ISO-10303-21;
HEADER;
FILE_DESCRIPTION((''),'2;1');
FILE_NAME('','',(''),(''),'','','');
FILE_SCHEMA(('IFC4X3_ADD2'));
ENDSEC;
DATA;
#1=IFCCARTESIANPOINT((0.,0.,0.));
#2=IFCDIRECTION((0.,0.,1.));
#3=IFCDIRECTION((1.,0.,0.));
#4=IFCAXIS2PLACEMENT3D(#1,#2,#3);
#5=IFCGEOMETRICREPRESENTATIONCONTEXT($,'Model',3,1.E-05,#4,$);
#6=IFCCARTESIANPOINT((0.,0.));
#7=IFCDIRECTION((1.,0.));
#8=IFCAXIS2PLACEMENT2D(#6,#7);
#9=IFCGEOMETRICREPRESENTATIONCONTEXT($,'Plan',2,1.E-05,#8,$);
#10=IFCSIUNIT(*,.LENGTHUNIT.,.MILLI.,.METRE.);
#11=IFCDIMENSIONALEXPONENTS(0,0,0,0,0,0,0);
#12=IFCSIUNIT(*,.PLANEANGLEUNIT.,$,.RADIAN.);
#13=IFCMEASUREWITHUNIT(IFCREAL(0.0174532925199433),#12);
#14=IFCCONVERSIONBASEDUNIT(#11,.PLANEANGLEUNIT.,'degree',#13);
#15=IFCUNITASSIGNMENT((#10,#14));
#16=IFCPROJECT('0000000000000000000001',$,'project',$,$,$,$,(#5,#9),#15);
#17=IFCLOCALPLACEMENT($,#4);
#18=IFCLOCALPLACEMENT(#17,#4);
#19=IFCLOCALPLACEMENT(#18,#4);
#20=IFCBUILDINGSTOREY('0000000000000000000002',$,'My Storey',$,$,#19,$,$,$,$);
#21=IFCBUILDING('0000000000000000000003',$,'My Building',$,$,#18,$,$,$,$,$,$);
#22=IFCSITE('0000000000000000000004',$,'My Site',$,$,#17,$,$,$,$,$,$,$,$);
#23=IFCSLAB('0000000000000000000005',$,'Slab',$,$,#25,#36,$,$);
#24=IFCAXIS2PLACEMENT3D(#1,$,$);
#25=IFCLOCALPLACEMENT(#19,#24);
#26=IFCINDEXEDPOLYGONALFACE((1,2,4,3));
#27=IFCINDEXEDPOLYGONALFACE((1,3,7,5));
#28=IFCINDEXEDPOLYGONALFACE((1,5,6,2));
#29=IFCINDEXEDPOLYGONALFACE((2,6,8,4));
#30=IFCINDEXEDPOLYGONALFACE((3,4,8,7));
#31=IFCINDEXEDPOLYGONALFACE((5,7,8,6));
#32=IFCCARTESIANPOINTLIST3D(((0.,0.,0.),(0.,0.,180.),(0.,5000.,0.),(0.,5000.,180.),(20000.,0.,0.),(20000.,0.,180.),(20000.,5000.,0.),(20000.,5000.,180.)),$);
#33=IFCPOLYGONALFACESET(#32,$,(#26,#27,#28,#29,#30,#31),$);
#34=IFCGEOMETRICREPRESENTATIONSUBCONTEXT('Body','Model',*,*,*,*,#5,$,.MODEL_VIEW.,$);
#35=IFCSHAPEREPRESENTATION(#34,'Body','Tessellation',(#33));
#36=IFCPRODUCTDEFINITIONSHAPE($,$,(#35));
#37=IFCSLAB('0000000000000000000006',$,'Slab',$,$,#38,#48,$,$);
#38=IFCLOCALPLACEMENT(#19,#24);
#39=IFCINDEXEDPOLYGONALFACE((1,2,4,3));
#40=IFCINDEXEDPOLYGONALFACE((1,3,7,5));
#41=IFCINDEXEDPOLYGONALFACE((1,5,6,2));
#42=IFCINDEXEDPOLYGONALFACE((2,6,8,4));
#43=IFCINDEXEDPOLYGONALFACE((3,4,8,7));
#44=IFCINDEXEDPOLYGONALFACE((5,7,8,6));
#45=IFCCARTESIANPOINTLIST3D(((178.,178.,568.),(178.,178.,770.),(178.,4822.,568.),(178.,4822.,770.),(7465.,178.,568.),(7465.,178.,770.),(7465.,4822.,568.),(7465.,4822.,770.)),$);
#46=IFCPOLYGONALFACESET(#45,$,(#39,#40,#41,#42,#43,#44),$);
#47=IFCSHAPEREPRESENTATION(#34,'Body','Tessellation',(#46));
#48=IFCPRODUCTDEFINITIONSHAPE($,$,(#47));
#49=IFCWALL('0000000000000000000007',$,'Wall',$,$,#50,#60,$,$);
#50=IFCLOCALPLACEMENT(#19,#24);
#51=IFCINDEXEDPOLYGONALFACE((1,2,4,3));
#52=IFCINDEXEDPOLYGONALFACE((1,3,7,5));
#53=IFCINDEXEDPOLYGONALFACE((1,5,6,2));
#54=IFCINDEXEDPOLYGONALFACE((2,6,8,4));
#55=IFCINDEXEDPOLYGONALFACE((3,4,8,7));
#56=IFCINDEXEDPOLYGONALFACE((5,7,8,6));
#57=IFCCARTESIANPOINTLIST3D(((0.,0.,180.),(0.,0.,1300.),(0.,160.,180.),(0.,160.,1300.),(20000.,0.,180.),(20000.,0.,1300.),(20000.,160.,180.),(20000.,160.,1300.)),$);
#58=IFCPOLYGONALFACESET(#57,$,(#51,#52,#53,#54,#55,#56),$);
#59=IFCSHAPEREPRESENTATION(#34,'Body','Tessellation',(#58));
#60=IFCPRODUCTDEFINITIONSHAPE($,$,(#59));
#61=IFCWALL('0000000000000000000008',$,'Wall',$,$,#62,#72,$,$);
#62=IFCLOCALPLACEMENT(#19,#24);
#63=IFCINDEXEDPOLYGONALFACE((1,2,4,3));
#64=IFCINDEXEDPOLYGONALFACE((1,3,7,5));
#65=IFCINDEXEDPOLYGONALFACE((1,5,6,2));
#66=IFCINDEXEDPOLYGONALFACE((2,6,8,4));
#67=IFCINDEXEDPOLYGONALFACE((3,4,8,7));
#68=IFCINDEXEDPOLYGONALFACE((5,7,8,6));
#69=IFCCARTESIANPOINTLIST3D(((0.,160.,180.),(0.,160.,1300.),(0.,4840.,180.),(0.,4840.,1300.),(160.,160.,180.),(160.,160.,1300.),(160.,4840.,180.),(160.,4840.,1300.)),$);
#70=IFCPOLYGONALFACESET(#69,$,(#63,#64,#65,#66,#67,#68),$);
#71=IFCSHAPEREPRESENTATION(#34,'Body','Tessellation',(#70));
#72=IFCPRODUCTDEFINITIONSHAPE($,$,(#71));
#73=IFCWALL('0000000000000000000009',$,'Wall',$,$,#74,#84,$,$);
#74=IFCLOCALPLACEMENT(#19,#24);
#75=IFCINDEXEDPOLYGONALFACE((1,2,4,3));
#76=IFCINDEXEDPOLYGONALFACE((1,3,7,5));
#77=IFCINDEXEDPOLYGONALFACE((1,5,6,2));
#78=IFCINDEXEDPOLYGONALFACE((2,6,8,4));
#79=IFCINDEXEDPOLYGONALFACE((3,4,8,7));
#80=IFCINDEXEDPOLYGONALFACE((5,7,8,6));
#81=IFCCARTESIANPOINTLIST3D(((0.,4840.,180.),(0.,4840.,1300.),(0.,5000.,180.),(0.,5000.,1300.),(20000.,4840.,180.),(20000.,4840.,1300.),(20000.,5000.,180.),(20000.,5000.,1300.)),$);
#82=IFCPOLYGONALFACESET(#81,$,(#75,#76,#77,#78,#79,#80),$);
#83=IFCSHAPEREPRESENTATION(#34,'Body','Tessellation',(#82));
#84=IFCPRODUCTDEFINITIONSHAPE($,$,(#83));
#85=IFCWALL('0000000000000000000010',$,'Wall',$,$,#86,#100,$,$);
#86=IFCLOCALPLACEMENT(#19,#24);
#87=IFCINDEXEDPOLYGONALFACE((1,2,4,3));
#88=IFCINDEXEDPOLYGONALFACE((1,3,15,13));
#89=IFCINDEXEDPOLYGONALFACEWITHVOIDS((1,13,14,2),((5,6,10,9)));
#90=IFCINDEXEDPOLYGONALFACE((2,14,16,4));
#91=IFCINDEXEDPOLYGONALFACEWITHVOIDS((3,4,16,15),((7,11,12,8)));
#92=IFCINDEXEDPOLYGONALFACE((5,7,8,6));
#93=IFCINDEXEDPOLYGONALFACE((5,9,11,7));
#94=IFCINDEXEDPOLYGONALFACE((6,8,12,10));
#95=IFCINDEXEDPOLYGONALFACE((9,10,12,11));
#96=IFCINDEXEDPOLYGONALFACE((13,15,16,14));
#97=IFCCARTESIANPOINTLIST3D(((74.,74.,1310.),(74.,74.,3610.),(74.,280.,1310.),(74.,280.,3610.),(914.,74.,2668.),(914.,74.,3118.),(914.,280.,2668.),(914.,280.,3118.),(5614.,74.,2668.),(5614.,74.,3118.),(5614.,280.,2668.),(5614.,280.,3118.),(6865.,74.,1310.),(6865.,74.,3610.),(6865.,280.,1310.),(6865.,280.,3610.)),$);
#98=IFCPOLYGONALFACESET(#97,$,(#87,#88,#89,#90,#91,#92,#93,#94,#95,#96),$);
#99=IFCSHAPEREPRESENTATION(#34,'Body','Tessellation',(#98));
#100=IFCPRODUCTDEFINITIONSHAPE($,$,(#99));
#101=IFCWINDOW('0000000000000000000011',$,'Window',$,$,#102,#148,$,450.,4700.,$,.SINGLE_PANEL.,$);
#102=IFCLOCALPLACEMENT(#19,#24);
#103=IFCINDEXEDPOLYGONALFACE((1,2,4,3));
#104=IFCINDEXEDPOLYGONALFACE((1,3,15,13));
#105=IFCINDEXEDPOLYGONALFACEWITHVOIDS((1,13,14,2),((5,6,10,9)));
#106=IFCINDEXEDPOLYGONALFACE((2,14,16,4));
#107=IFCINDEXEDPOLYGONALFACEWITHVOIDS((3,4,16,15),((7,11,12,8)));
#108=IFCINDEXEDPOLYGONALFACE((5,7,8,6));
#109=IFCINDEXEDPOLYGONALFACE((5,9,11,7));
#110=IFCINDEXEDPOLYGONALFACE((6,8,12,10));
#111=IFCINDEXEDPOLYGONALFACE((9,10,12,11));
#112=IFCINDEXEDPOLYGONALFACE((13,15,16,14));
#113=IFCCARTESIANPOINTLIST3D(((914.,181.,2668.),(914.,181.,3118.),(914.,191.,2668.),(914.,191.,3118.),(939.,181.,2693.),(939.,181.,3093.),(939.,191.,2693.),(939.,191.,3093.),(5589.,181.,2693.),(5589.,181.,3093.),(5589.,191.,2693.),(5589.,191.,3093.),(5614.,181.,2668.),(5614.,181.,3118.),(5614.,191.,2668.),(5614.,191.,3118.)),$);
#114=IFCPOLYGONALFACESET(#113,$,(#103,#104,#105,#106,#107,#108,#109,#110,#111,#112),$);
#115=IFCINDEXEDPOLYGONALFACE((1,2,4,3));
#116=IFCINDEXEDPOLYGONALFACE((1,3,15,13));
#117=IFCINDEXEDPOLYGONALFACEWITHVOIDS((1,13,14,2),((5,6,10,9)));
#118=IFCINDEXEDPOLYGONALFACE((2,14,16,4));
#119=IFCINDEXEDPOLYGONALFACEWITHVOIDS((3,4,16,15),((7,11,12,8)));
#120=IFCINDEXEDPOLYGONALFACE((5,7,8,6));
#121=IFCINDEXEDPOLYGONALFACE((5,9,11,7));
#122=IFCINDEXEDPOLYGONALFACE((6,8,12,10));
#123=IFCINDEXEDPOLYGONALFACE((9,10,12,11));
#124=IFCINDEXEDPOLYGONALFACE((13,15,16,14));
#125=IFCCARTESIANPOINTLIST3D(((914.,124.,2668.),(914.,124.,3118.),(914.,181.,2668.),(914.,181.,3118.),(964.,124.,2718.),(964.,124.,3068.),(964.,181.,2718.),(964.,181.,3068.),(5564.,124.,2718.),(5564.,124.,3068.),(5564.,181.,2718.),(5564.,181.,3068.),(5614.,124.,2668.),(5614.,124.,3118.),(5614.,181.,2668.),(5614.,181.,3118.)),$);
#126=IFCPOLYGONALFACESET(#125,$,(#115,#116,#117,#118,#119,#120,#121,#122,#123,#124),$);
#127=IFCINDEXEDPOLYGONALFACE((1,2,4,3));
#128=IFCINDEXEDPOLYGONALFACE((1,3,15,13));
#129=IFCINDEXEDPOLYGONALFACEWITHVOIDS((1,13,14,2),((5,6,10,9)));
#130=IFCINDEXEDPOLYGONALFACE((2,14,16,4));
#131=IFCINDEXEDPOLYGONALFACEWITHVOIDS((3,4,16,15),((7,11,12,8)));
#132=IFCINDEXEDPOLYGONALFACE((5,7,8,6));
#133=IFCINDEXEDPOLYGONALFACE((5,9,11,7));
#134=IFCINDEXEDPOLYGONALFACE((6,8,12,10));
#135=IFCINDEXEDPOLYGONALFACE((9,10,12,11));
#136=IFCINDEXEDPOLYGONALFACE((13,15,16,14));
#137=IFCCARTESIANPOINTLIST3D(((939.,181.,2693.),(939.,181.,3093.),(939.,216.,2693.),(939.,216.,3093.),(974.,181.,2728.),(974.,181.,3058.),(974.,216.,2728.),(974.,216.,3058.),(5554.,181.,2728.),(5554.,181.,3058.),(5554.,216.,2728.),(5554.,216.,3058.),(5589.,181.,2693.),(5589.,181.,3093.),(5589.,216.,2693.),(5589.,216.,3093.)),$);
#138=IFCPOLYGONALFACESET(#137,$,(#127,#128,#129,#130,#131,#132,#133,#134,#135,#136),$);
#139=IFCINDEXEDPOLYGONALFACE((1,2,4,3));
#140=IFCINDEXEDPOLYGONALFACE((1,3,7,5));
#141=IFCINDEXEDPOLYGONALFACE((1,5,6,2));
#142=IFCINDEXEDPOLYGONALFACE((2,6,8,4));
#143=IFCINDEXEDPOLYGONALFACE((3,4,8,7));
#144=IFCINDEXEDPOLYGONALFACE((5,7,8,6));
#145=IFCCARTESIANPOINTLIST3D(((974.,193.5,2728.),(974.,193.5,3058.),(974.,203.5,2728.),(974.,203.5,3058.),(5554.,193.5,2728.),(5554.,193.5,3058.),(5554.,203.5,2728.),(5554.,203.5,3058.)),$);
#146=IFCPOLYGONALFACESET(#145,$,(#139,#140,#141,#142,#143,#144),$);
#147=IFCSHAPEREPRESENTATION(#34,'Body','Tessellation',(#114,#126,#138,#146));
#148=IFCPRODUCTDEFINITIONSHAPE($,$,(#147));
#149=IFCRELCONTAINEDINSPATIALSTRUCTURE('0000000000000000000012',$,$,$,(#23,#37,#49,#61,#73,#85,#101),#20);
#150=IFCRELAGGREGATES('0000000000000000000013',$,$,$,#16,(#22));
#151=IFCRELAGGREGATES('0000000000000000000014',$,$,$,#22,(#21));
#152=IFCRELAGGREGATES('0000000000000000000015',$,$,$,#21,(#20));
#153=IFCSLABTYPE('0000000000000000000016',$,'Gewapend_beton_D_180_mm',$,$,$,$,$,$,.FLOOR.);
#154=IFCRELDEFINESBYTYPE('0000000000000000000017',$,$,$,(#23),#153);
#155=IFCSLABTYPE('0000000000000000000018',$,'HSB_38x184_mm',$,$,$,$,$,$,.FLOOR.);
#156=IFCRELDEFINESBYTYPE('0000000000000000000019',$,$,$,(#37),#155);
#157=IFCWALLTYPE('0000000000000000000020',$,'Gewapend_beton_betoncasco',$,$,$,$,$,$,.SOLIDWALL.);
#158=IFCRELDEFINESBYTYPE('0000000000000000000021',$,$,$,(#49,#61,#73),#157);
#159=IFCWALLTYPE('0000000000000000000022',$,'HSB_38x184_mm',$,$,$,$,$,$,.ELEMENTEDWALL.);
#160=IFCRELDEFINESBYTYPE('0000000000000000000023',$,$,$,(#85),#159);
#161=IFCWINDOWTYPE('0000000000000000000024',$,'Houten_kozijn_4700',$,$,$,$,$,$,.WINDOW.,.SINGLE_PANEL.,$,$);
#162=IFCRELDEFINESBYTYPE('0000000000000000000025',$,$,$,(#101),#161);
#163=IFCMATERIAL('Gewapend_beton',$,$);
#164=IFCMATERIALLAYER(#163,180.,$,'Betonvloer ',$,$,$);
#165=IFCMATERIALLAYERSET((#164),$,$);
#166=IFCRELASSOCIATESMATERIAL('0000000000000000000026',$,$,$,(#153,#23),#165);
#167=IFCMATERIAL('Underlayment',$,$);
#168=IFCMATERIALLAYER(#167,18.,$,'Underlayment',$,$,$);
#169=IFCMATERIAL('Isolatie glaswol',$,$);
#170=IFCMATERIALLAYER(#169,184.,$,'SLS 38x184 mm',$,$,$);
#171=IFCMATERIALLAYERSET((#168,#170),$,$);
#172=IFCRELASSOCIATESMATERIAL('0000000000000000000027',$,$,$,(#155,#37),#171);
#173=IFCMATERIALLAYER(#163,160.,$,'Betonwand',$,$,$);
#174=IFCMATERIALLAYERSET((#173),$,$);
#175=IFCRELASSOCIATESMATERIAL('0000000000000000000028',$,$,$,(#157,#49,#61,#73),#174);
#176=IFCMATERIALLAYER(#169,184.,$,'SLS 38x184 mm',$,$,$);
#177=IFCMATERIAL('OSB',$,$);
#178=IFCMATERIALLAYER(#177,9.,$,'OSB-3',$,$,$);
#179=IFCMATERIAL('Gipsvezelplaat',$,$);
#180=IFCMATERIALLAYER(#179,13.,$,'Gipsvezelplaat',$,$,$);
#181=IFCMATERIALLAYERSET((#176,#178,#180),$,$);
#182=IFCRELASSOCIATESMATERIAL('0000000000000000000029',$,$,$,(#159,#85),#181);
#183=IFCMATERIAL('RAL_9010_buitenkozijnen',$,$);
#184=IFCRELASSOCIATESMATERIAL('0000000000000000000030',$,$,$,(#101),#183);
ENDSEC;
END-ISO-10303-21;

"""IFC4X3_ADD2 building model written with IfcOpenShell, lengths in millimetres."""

from ifc_helpers import new_model, entity, si_unit, converted_unit, frame, origin_with_axes, origin_2d_with_axis, place, context, subcontext, project, spatial, line, indexed_curve, outline, extrude, shape, source, transform, mapped, material, layer, layer_set, layer_usage, type_object, type_shapes, element, fill, save


model = new_model("IFC4X3_ADD2")

# Units and contexts
model_context = context("Model", 3, precision=1e-05, world=origin_with_axes())
plan_context = context("Plan", 2, precision=1e-05, world=origin_2d_with_axis())
body_context_1 = subcontext(model_context, "Body", "Model", "MODEL_VIEW")
body_context_2 = subcontext(plan_context, "Body", "Plan", "PLAN_VIEW")
ifc_project = project(units=[si_unit("LENGTHUNIT", "METRE", prefix="MILLI"), converted_unit("PLANEANGLEUNIT", "degree", entity("IfcReal", 0.0174532925199433), si_unit("PLANEANGLEUNIT", "RADIAN"), dimensions=[0, 0, 0, 0, 0, 0, 0])], contexts=[model_context, plan_context])

# Site, building, storey
site_placement = place(None, origin_with_axes())
site = spatial("IfcSite", under=ifc_project, at=site_placement, Name="My Site")
building_placement = place(site_placement, origin_with_axes())
building = spatial("IfcBuilding", under=site, at=building_placement, Name="My Building")
storey_placement = place(building_placement, origin_with_axes())
storey = spatial("IfcBuildingStorey", under=building, at=storey_placement, Name="My Storey")

# Slabs
ifc_material_1 = material(Name="Gewapend_beton")
ifc_layer_1 = layer(ifc_material_1, 180.0, Name="Betonvloer ")
ifc_layer_set_1 = layer_set([ifc_layer_1])
ifc_layer_usage_1 = layer_usage(ifc_layer_set_1, "AXIS3", "POSITIVE", 0.0)
slab_type_1 = type_object("IfcSlabType", Name="Gewapend_beton_D_180_mm", PredefinedType="FLOOR", material=ifc_layer_set_1)
slab_1_placement = place(storey_placement, origin_with_axes())
element("IfcSlab", 1, at=slab_1_placement, inside=storey, type_object=slab_type_1, material=ifc_layer_usage_1, Name="Slab", context=body_context_1, shape_type="SweptSolid", body=[
    extrude(outline(indexed_curve([(20000.0, 5000.0), (0.0, 5000.0), (0.0, 0.0), (20000.0, 0.0)], segments=[line(4, 1), line(1, 2), line(2, 3), line(3, 4)], self_intersect=False)), None, (0.0, 0.0, 1.0), 180.0),
])
ifc_material_2 = material(Name="Underlayment")
ifc_layer_2 = layer(ifc_material_2, 18.0, Name="Underlayment")
ifc_material_3 = material(Name="Isolatie glaswol")
ifc_layer_3 = layer(ifc_material_3, 184.0, Name="SLS 38x184 mm")
ifc_layer_set_2 = layer_set([ifc_layer_2, ifc_layer_3])
ifc_layer_usage_2 = layer_usage(ifc_layer_set_2, "AXIS3", "POSITIVE", 0.0)
slab_type_2 = type_object("IfcSlabType", Name="HSB_38x184_mm", PredefinedType="FLOOR", material=ifc_layer_set_2)
slab_2_placement = place(storey_placement, frame((178.0, 178.0, 568.0), z_axis=(0.0, 0.0, 1.0), x_axis=(1.0, 0.0, 0.0)))
element("IfcSlab", 2, at=slab_2_placement, inside=storey, type_object=slab_type_2, material=ifc_layer_usage_2, Name="Slab", context=body_context_1, shape_type="SweptSolid", body=[
    extrude(outline(indexed_curve([(0.0, 0.0), (7287.0, 0.0), (7287.0, 4644.0), (0.0, 4644.0)], segments=[line(3, 2), line(2, 1), line(1, 4), line(4, 3)], self_intersect=False)), None, (0.0, 0.0, 1.0), 202.0),
])

# Walls
ifc_layer_4 = layer(ifc_material_1, 160.0, Name="Betonwand")
ifc_layer_set_3 = layer_set([ifc_layer_4])
ifc_layer_usage_3 = layer_usage(ifc_layer_set_3, "AXIS2", "POSITIVE", 0.0)
wall_type_1 = type_object("IfcWallType", Name="Gewapend_beton_betoncasco", PredefinedType="SOLIDWALL", material=ifc_layer_set_3)
wall_1_placement = place(storey_placement, frame((0.0, 0.0, 180.0), z_axis=(0.0, 0.0, 1.0), x_axis=(1.0, 0.0, 0.0)))
element("IfcWall", 3, at=wall_1_placement, inside=storey, type_object=wall_type_1, material=ifc_layer_usage_3, Name="Wall", context=body_context_1, shape_type="SweptSolid", body=[
    extrude(outline(indexed_curve([(0.0, 0.0), (0.0, 160.0), (20000.0, 160.0), (20000.0, 0.0), (0.0, 0.0)], self_intersect=False)), origin_with_axes(), (0.0, 0.0, 1.0), 1120.0),
])
ifc_layer_usage_4 = layer_usage(ifc_layer_set_3, "AXIS2", "POSITIVE", 0.0)
wall_2_placement = place(storey_placement, frame((160.0, 160.0, 180.0), z_axis=(0.0, 0.0, 1.0), x_axis=(0.0, 1.0, 0.0)))
element("IfcWall", 4, at=wall_2_placement, inside=storey, type_object=wall_type_1, material=ifc_layer_usage_4, Name="Wall", context=body_context_1, shape_type="SweptSolid", body=[
    extrude(outline(indexed_curve([(0.0, 0.0), (0.0, 160.0), (4680.0, 160.0), (4680.0, 0.0), (0.0, 0.0)], self_intersect=False)), origin_with_axes(), (0.0, 0.0, 1.0), 1120.0),
])
ifc_layer_usage_5 = layer_usage(ifc_layer_set_3, "AXIS2", "POSITIVE", 0.0)
wall_3_placement = place(storey_placement, frame((0.0, 4840.0, 180.0), z_axis=(0.0, 0.0, 1.0), x_axis=(1.0, 0.0, 0.0)))
element("IfcWall", 5, at=wall_3_placement, inside=storey, type_object=wall_type_1, material=ifc_layer_usage_5, Name="Wall", context=body_context_1, shape_type="SweptSolid", body=[
    extrude(outline(indexed_curve([(0.0, 0.0), (0.0, 160.0), (20000.0, 160.0), (20000.0, 0.0), (0.0, 0.0)], self_intersect=False)), origin_with_axes(), (0.0, 0.0, 1.0), 1120.0),
])

# Wall, opening, window
ifc_layer_5 = layer(ifc_material_3, 184.0, Name="SLS 38x184 mm")
ifc_material_4 = material(Name="OSB")
ifc_layer_6 = layer(ifc_material_4, 9.0, Name="OSB-3")
ifc_material_5 = material(Name="Gipsvezelplaat")
ifc_layer_7 = layer(ifc_material_5, 13.0, Name="Gipsvezelplaat")
ifc_layer_set_4 = layer_set([ifc_layer_5, ifc_layer_6, ifc_layer_7])
ifc_layer_usage_6 = layer_usage(ifc_layer_set_4, "AXIS2", "POSITIVE", 0.0)
wall_type_2 = type_object("IfcWallType", Name="HSB_38x184_mm", PredefinedType="ELEMENTEDWALL", material=ifc_layer_set_4)
wall_4_placement = place(storey_placement, frame((74.0, 74.0, 1310.0), z_axis=(0.0, 0.0, 1.0), x_axis=(1.0, 0.0, 0.0)))
wall_4 = element("IfcWall", 6, at=wall_4_placement, inside=storey, type_object=wall_type_2, material=ifc_layer_usage_6, Name="Wall", context=body_context_1, shape_type="SweptSolid", body=[
    extrude(outline(indexed_curve([(0.0, 0.0), (0.0, 206.0), (6791.0, 206.0), (6791.0, 0.0), (0.0, 0.0)], self_intersect=False)), origin_with_axes(), (0.0, 0.0, 1.0), 2300.0),
])
shared_shape_1 = source(origin_with_axes(), body_context_1, "Body", "SweptSolid", [
    extrude(outline(indexed_curve([(0.0, 0.0), (4700.0, 0.0), (4700.0, 450.0), (0.0, 450.0)], segments=[line(1, 2, 3, 4, 1)])), frame((0.0, -600.0, 0.0), z_axis=(0.0, -1.0, 0.0), x_axis=(1.0, 0.0, 0.0)), (0.0, 0.0, -1.0), 1200.0),
])
opening_1_placement = place(wall_4_placement, frame((840.0, 0.0, 1358.0), z_axis=(0.0, 0.0, 1.0), x_axis=(1.0, 0.0, 0.0)))
opening_1 = element("IfcOpeningElement", 7, at=opening_1_placement, cuts=wall_4, PredefinedType="OPENING", context=body_context_1, shape_type="MappedRepresentation", body=[
    mapped(shared_shape_1, transform((0.0, 0.0, 0.0), x_axis=(1.0, 0.0, 0.0), y_axis=(0.0, 1.0, 0.0), z_axis=(0.0, 0.0, 1.0), scale=1.0)),
])
ifc_material_6 = material(Name="RAL_9010_buitenkozijnen")
window_type_1 = type_object("IfcWindowType", Name="Houten_kozijn_4700", PartitioningType="SINGLE_PANEL", PredefinedType="WINDOW")
shared_shape_2 = source(origin_with_axes(), body_context_1, "Body", "SweptSolid", [
    extrude(outline(indexed_curve([(0.0, 0.0), (4700.0, 0.0), (4700.0, 450.0), (0.0, 450.0)], segments=[line(1, 2, 3, 4, 1)]), holes=[indexed_curve([(25.0, 25.0), (4675.0, 25.0), (4675.0, 425.0), (25.0, 425.0)], segments=[line(1, 2, 3, 4, 1)])]), frame((0.0, 107.0, 0.0), z_axis=(0.0, -1.0, 0.0), x_axis=(1.0, 0.0, 0.0)), (0.0, 0.0, -1.0), 10.0),
    extrude(outline(indexed_curve([(0.0, 0.0), (4700.0, 0.0), (4700.0, 450.0), (0.0, 450.0)], segments=[line(1, 2, 3, 4, 1)]), holes=[indexed_curve([(50.0, 50.0), (4650.0, 50.0), (4650.0, 400.0), (50.0, 400.0)], segments=[line(1, 2, 3, 4, 1)])]), frame((0.0, 50.0, 0.0), z_axis=(0.0, -1.0, 0.0), x_axis=(1.0, 0.0, 0.0)), (0.0, 0.0, -1.0), 57.0),
    extrude(outline(indexed_curve([(0.0, 0.0), (4650.0, 0.0), (4650.0, 400.0), (0.0, 400.0)], segments=[line(1, 2, 3, 4, 1)]), holes=[indexed_curve([(35.0, 35.0), (4615.0, 35.0), (4615.0, 365.0), (35.0, 365.0)], segments=[line(1, 2, 3, 4, 1)])]), frame((25.0, 107.0, 25.0), z_axis=(0.0, -1.0, 0.0), x_axis=(1.0, 0.0, 0.0)), (0.0, 0.0, -1.0), 35.0),
    extrude(outline(indexed_curve([(35.0, 35.0), (4615.0, 35.0), (4615.0, 365.0), (35.0, 365.0)], segments=[line(1, 2, 3, 4, 1)])), frame((25.0, 119.5, 25.0), z_axis=(0.0, -1.0, 0.0), x_axis=(1.0, 0.0, 0.0)), (0.0, 0.0, -1.0), 10.0),
])
shared_shape_3 = source(origin_with_axes(), body_context_2, "Body", "Curve2D", [
    entity("IfcIndexedPolyCurve", entity("IfcCartesianPointList2D", [[50.0, 50.0], [4650.0, 50.0]])),
    entity("IfcIndexedPolyCurve", entity("IfcCartesianPointList2D", [[0.0, 117.0], [25.0, 117.0], [25.0, 107.0], [50.0, 107.0], [50.0, 50.0], [0.0, 50.0]]), [entity("IfcLineIndex", [1, 2, 3, 4, 5, 6, 1])]),
    entity("IfcIndexedPolyCurve", entity("IfcCartesianPointList2D", [[4700.0, 117.0], [4675.0, 117.0], [4675.0, 107.0], [4650.0, 107.0], [4650.0, 50.0], [4700.0, 50.0]]), [entity("IfcLineIndex", [1, 2, 3, 4, 5, 6, 1])]),
    entity("IfcIndexedPolyCurve", entity("IfcCartesianPointList2D", [[25.0, 107.0], [60.0, 107.0], [60.0, 142.0], [25.0, 142.0]]), [entity("IfcLineIndex", [1, 2, 3, 4, 1])]),
    entity("IfcIndexedPolyCurve", entity("IfcCartesianPointList2D", [[4675.0, 107.0], [4640.0, 107.0], [4640.0, 142.0], [4675.0, 142.0]]), [entity("IfcLineIndex", [1, 2, 3, 4, 1])]),
    entity("IfcIndexedPolyCurve", entity("IfcCartesianPointList2D", [[60.0, 107.0], [4640.0, 107.0]])),
    entity("IfcIndexedPolyCurve", entity("IfcCartesianPointList2D", [[60.0, 142.0], [4640.0, 142.0]])),
    entity("IfcIndexedPolyCurve", entity("IfcCartesianPointList2D", [[60.0, 124.5], [4640.0, 124.5]])),
])
type_shapes(window_type_1, [shared_shape_2, shared_shape_3])
window_1_placement = place(opening_1_placement, origin_with_axes())
window_1 = element("IfcWindow", 8, at=window_1_placement, inside=storey, type_object=window_type_1, material=ifc_material_6, Name="Window", OverallHeight=450.0, OverallWidth=4700.0, PartitioningType="SINGLE_PANEL", shapes=[
    shape(body_context_1, "Body", "MappedRepresentation", [mapped(shared_shape_2, transform((0.0, 0.0, 0.0), x_axis=(1.0, 0.0, 0.0), y_axis=(0.0, 1.0, 0.0), z_axis=(0.0, 0.0, 1.0), scale=1.0))]),
    shape(body_context_2, "Body", "MappedRepresentation", [mapped(shared_shape_3, transform((0.0, 0.0, 0.0), x_axis=(1.0, 0.0, 0.0), y_axis=(0.0, 1.0, 0.0), z_axis=(0.0, 0.0, 1.0), scale=1.0))]),
])
fill(opening_1, window_1)

save(model, "model.ifc")
